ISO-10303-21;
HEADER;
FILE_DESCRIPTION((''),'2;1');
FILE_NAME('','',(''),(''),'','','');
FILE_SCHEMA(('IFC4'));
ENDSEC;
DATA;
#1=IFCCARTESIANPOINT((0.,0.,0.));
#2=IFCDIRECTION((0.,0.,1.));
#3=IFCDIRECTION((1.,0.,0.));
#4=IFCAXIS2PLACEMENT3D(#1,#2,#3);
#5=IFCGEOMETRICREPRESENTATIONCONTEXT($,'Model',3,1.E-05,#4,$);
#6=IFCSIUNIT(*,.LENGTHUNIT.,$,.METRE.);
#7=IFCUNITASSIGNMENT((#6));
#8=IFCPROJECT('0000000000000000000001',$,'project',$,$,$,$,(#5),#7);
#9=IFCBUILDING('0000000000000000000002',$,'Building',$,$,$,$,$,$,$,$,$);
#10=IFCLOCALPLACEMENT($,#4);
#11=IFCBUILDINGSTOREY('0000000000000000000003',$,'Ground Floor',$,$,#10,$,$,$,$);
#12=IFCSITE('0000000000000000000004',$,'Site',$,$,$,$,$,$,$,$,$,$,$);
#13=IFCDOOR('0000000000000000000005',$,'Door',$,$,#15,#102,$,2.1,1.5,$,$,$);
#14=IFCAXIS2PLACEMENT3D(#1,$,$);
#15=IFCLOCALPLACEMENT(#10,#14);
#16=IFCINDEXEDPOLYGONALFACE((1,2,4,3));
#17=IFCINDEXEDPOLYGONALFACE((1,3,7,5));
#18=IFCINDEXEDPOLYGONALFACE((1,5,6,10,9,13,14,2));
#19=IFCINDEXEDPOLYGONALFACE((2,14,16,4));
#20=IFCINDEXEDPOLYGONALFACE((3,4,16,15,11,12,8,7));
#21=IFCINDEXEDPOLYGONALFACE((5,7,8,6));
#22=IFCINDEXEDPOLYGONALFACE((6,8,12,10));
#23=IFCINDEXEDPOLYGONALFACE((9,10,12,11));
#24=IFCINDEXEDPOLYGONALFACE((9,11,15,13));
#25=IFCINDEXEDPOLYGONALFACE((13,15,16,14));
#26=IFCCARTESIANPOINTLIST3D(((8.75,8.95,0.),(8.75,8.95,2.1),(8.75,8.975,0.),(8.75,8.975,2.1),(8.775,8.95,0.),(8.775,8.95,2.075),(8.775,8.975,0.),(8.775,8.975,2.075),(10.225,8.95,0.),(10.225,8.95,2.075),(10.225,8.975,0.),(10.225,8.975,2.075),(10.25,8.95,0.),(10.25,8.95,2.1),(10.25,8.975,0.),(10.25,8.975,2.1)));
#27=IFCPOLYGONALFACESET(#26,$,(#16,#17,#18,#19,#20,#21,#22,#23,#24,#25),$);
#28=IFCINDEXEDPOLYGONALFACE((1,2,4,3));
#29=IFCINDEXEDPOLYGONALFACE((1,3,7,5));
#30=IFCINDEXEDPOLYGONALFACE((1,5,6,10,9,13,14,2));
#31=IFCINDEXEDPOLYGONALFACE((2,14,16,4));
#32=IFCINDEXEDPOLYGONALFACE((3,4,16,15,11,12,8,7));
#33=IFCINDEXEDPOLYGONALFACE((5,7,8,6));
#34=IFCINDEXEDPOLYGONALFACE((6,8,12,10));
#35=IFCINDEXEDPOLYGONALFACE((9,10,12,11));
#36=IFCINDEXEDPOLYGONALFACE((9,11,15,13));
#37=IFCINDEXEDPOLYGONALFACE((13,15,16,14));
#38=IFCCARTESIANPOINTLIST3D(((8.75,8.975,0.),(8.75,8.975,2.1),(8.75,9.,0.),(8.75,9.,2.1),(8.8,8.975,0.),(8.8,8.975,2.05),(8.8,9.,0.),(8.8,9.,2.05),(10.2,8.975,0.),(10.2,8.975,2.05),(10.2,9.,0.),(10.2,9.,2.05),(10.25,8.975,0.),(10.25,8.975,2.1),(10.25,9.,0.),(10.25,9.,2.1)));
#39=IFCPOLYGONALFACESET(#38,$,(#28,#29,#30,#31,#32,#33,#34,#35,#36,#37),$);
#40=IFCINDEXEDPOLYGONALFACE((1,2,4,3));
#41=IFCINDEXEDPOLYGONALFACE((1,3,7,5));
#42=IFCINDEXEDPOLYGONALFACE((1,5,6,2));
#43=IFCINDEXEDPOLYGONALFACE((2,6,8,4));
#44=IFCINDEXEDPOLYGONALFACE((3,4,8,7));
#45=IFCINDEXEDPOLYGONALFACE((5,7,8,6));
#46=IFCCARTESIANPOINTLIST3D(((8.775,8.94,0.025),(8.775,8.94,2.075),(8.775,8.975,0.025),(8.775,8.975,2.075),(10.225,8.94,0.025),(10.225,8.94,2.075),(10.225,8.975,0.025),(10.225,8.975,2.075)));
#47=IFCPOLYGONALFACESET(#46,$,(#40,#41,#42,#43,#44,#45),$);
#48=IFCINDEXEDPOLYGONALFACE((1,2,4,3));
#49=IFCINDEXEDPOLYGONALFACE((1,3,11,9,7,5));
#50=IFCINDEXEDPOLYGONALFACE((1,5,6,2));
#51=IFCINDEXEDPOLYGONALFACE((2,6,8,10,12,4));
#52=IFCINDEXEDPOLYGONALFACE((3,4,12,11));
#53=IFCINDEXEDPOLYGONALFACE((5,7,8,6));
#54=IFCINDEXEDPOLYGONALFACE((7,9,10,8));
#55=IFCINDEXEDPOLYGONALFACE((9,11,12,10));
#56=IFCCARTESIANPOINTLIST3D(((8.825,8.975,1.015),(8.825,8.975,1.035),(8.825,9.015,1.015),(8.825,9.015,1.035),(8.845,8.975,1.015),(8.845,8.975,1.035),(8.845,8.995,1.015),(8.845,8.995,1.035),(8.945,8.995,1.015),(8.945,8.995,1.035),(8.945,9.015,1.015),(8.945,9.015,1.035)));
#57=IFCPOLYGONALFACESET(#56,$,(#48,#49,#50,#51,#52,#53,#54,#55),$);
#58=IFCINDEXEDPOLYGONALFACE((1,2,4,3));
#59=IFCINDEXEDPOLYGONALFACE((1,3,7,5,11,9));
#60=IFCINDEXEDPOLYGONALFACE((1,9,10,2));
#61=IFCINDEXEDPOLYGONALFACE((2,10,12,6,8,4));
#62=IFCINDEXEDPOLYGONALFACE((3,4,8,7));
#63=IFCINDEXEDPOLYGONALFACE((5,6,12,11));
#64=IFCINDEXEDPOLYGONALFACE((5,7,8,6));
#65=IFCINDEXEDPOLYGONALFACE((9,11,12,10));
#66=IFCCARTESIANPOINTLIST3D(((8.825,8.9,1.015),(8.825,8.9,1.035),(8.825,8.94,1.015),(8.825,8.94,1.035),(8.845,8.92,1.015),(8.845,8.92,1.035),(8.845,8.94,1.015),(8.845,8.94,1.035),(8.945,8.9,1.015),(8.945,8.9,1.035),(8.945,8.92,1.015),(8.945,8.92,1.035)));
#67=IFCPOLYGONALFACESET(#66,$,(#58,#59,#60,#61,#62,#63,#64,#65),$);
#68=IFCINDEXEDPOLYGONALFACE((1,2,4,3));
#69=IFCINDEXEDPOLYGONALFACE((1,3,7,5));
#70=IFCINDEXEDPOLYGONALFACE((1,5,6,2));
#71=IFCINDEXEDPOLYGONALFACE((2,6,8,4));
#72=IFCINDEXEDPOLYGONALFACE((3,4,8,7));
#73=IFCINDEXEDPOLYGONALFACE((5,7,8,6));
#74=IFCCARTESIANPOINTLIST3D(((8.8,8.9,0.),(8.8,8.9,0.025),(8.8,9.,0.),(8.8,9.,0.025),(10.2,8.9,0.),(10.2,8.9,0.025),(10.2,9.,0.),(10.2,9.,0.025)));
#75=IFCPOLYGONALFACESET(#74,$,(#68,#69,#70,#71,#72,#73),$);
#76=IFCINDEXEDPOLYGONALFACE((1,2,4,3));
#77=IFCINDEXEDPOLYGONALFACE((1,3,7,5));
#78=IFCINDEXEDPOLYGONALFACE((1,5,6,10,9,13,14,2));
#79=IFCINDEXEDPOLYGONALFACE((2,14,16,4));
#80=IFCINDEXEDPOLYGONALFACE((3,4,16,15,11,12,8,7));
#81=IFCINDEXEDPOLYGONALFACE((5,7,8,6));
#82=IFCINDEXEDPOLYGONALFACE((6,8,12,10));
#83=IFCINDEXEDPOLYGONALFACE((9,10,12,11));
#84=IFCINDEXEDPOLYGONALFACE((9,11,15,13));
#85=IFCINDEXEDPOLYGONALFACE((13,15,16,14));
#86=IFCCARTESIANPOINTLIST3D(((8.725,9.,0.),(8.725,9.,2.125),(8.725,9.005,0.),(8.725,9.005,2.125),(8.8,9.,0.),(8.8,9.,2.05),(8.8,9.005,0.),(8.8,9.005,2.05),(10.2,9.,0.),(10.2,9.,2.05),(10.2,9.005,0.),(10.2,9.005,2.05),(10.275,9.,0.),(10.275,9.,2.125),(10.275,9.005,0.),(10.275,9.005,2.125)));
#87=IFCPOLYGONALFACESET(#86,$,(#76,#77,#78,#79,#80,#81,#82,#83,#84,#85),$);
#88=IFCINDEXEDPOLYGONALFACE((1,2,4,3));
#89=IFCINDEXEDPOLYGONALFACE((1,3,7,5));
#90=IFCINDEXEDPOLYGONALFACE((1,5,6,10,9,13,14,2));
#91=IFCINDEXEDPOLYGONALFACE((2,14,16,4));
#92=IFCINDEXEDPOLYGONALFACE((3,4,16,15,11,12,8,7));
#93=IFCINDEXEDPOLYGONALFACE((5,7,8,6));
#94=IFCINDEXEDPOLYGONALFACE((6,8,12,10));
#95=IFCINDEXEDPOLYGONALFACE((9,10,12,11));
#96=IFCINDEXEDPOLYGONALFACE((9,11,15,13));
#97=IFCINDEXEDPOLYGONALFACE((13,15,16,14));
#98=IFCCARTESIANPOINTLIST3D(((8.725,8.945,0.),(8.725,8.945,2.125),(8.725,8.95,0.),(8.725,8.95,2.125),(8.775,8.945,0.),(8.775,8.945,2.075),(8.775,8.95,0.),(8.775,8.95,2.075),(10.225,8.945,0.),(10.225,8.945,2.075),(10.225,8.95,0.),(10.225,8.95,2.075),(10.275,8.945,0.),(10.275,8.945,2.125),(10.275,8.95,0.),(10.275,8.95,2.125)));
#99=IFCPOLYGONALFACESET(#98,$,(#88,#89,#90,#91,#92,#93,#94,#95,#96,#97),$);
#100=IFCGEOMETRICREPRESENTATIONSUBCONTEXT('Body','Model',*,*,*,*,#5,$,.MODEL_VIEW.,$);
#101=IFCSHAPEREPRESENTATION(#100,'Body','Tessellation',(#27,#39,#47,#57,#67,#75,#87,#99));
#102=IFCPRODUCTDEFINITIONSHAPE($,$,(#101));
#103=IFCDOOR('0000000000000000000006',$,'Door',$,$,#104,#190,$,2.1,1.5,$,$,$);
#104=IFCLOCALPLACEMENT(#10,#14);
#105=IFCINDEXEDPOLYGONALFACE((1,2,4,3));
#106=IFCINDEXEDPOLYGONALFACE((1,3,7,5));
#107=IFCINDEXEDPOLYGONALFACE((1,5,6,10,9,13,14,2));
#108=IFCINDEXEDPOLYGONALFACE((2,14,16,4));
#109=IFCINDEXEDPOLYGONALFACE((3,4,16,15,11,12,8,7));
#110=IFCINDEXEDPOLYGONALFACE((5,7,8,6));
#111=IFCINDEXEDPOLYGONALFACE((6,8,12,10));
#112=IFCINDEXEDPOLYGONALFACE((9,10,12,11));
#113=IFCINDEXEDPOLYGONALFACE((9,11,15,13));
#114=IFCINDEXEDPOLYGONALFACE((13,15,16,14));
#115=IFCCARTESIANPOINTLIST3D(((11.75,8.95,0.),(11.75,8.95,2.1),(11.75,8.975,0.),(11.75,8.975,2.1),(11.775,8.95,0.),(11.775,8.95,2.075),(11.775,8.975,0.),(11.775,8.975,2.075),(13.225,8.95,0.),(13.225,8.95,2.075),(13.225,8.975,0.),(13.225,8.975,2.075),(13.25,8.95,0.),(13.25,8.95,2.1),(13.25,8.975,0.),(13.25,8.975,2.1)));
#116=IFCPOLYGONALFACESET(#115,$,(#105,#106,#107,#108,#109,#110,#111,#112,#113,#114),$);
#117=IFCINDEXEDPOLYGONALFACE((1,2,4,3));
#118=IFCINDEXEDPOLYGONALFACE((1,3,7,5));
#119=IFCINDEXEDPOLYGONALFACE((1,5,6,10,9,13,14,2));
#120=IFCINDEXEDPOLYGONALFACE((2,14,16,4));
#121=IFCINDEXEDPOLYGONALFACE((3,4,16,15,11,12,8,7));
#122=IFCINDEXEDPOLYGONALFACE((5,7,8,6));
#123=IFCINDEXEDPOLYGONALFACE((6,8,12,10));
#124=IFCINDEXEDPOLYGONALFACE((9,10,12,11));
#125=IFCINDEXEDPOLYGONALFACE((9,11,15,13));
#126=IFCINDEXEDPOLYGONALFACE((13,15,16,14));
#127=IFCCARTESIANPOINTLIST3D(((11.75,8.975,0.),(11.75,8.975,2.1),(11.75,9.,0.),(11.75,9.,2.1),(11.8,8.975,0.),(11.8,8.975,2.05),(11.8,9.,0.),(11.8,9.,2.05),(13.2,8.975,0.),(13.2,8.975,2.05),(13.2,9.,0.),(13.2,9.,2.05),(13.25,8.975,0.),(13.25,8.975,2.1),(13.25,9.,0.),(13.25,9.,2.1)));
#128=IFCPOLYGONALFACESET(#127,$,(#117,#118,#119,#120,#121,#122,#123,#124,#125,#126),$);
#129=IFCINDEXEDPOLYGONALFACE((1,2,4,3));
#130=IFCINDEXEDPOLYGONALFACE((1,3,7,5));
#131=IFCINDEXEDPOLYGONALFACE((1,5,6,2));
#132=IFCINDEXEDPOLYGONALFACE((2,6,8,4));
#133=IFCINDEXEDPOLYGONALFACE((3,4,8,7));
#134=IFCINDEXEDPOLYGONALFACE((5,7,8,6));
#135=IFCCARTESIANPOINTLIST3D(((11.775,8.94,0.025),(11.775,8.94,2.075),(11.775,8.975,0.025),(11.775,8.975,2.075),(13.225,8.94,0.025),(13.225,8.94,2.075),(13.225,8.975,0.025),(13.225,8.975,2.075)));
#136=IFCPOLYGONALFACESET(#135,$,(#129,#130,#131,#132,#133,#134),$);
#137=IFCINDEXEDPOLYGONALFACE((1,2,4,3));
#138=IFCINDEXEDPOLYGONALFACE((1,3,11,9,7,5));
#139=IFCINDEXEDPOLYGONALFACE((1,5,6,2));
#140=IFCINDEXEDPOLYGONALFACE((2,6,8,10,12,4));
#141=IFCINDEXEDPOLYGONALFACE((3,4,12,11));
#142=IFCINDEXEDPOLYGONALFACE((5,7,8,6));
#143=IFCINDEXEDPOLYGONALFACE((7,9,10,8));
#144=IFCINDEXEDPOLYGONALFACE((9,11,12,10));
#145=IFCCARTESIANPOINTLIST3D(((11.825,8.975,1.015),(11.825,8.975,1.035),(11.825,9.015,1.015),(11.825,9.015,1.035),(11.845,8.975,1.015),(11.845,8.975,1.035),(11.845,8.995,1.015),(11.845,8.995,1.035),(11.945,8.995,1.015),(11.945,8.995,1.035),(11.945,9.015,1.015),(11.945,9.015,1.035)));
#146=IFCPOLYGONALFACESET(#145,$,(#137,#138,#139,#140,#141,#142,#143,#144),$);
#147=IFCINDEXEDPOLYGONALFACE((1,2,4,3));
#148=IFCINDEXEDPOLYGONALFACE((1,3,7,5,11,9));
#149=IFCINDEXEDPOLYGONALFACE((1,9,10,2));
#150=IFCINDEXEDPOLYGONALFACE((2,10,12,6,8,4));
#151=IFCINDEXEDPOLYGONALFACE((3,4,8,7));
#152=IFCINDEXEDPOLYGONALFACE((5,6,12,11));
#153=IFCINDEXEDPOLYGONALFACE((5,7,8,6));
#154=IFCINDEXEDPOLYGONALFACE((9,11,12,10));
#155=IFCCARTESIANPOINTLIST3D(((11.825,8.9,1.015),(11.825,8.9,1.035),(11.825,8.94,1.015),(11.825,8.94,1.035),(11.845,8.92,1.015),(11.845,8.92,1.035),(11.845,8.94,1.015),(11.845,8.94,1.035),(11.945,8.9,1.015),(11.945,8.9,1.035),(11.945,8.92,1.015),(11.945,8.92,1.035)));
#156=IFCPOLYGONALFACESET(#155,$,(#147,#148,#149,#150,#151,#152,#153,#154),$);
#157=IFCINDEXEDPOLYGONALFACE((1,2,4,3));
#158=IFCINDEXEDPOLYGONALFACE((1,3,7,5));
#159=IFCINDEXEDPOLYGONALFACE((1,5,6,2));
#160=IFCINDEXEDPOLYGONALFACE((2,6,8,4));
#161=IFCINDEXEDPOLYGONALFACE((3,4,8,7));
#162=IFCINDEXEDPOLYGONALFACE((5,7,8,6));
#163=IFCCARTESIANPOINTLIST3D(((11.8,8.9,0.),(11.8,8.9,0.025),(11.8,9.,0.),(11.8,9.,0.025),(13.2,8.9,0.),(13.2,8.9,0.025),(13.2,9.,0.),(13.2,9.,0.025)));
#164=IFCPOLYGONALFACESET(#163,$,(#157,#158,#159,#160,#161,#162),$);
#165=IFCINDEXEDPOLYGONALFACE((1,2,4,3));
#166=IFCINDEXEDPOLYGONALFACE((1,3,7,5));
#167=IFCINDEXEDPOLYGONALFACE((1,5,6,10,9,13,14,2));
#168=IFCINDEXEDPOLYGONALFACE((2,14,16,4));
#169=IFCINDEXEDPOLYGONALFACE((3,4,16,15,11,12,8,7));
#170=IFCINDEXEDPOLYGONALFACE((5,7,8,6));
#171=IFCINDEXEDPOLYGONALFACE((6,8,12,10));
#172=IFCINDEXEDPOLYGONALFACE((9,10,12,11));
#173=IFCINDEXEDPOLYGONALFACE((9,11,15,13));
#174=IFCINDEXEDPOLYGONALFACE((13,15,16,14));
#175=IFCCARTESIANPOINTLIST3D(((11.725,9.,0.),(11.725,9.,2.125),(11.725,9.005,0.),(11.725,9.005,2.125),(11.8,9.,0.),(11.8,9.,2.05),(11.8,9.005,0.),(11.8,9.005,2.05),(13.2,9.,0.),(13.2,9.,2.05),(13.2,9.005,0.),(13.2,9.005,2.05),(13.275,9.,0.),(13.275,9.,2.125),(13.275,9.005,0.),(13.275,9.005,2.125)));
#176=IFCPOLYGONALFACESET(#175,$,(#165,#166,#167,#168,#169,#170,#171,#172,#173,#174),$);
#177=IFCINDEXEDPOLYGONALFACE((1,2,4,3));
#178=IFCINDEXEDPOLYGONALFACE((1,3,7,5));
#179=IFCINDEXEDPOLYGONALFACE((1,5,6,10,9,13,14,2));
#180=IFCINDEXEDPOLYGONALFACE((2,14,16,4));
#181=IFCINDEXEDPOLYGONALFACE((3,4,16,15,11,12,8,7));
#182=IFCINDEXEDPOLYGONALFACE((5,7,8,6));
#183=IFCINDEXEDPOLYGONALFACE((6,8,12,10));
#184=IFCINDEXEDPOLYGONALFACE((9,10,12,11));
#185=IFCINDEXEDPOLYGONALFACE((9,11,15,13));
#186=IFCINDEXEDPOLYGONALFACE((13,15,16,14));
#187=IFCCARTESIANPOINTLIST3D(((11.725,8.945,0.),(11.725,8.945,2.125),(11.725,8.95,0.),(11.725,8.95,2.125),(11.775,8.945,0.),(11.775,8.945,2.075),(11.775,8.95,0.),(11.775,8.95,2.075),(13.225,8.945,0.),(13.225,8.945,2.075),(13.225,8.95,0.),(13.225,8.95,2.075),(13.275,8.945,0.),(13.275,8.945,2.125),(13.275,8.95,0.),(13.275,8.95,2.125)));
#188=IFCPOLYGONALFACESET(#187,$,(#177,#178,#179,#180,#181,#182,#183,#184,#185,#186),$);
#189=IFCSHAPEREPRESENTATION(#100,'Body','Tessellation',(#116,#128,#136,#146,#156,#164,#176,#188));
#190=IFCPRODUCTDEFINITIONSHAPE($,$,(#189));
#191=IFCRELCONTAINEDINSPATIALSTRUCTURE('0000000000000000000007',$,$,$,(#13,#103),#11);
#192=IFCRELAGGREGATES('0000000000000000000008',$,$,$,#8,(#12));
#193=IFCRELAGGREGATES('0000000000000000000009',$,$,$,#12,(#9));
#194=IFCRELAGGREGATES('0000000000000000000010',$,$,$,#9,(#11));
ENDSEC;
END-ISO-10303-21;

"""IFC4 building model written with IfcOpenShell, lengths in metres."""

from ifc_helpers import new_model, si_unit, frame, origin_with_axes, place, context, subcontext, project, spatial, line, indexed_curve, outline, extrude, element, save


model = new_model("IFC4")

# Units and contexts
model_context = context("Model", 3, precision=1e-05, world=origin_with_axes())
body_context = subcontext(model_context, "Body", "Model", "MODEL_VIEW")
ifc_project = project(units=[si_unit("LENGTHUNIT", "METRE")], contexts=[model_context])

# Site, building, storey
site = spatial("IfcSite", under=ifc_project, Name="Site")
building = spatial("IfcBuilding", under=site, Name="Building")
storey_placement = place(None, origin_with_axes())
storey = spatial("IfcBuildingStorey", under=building, at=storey_placement, Name="Ground Floor")

# Doors
door_1_placement = place(storey_placement, frame((10.25, 9.0, 0.0), z_axis=(0.0, 0.0, 1.0), x_axis=(-1.0, 0.0, 0.0)))
element("IfcDoor", 1, at=door_1_placement, inside=storey, Name="Door", OverallHeight=2.1, OverallWidth=1.5, context=body_context, shape_type="SweptSolid", body=[
    extrude(outline(indexed_curve([(0.0, 0.0), (0.0, 2.1), (1.5, 2.1), (1.5, 0.0), (1.475, 0.0), (1.475, 2.075), (0.025, 2.075), (0.025, 0.0)], segments=[line(1, 2, 3, 4, 5, 6, 7, 8, 1)])), frame((0.0, 0.025, 0.0), z_axis=(0.0, -1.0, 0.0), x_axis=(1.0, 0.0, 0.0)), (0.0, 0.0, -1.0), 0.025),
    extrude(outline(indexed_curve([(0.0, 0.0), (0.0, 2.1), (1.5, 2.1), (1.5, 0.0), (1.45, 0.0), (1.45, 2.05), (0.05, 2.05), (0.05, 0.0)], segments=[line(1, 2, 3, 4, 5, 6, 7, 8, 1)])), frame((0.0, 0.0, 0.0), z_axis=(0.0, -1.0, 0.0), x_axis=(1.0, 0.0, 0.0)), (0.0, 0.0, -1.0), 0.025),
    extrude(outline(indexed_curve([(0.0, 0.0), (1.45, 0.0), (1.45, 0.035), (0.0, 0.035)], segments=[line(1, 2, 3, 4, 1)])), frame((0.025, 0.025, 0.025), z_axis=(0.0, 0.0, 1.0), x_axis=(1.0, 0.0, 0.0)), (0.0, 0.0, 1.0), 2.05),
    extrude(outline(indexed_curve([(0.0, 0.0), (0.0, -0.04), (-0.12, -0.04), (-0.12, -0.02), (-0.02, -0.02), (-0.02, 0.0)], segments=[line(1, 2, 3, 4, 5, 6, 1)])), frame((1.425, 0.025, 1.015), z_axis=(0.0, 0.0, 1.0), x_axis=(1.0, 0.0, 0.0)), (0.0, 0.0, 1.0), 0.02),
    extrude(outline(indexed_curve([(0.0, 0.0), (0.0, 0.04), (-0.12, 0.04), (-0.12, 0.02), (-0.02, 0.02), (-0.02, 0.0)], segments=[line(1, 2, 3, 4, 5, 6, 1)])), frame((1.425, 0.06, 1.015), z_axis=(0.0, 0.0, 1.0), x_axis=(1.0, 0.0, 0.0)), (0.0, 0.0, 1.0), 0.02),
    extrude(outline(indexed_curve([(0.0, 0.0), (1.4, 0.0), (1.4, 0.1), (0.0, 0.1)], segments=[line(1, 2, 3, 4, 1)])), frame((0.05, 0.0, 0.0), z_axis=(0.0, 0.0, 1.0), x_axis=(1.0, 0.0, 0.0)), (0.0, 0.0, 1.0), 0.025),
    extrude(outline(indexed_curve([(0.0, 0.0), (0.0, 2.125), (1.55, 2.125), (1.55, 0.0), (1.475, 0.0), (1.475, 2.05), (0.075, 2.05), (0.075, 0.0)], segments=[line(1, 2, 3, 4, 5, 6, 7, 8, 1)])), frame((-0.025, -0.005, 0.0), z_axis=(0.0, -1.0, 0.0), x_axis=(1.0, 0.0, 0.0)), (0.0, 0.0, -1.0), 0.005),
    extrude(outline(indexed_curve([(0.0, 0.0), (0.0, 2.125), (1.55, 2.125), (1.55, 0.0), (1.5, 0.0), (1.5, 2.075), (0.05, 2.075), (0.05, 0.0)], segments=[line(1, 2, 3, 4, 5, 6, 7, 8, 1)])), frame((-0.025, 0.05, 0.0), z_axis=(0.0, -1.0, 0.0), x_axis=(1.0, 0.0, 0.0)), (0.0, 0.0, -1.0), 0.005),
])
door_2_placement = place(storey_placement, frame((13.25, 9.0, 0.0), z_axis=(0.0, 0.0, 1.0), x_axis=(-1.0, 0.0, 0.0)))
element("IfcDoor", 2, at=door_2_placement, inside=storey, Name="Door", OverallHeight=2.1, OverallWidth=1.5, context=body_context, shape_type="SweptSolid", body=[
    extrude(outline(indexed_curve([(0.0, 0.0), (0.0, 2.1), (1.5, 2.1), (1.5, 0.0), (1.475, 0.0), (1.475, 2.075), (0.025, 2.075), (0.025, 0.0)], segments=[line(1, 2, 3, 4, 5, 6, 7, 8, 1)])), frame((0.0, 0.025, 0.0), z_axis=(0.0, -1.0, 0.0), x_axis=(1.0, 0.0, 0.0)), (0.0, 0.0, -1.0), 0.025),
    extrude(outline(indexed_curve([(0.0, 0.0), (0.0, 2.1), (1.5, 2.1), (1.5, 0.0), (1.45, 0.0), (1.45, 2.05), (0.05, 2.05), (0.05, 0.0)], segments=[line(1, 2, 3, 4, 5, 6, 7, 8, 1)])), frame((0.0, 0.0, 0.0), z_axis=(0.0, -1.0, 0.0), x_axis=(1.0, 0.0, 0.0)), (0.0, 0.0, -1.0), 0.025),
    extrude(outline(indexed_curve([(0.0, 0.0), (1.45, 0.0), (1.45, 0.035), (0.0, 0.035)], segments=[line(1, 2, 3, 4, 1)])), frame((0.025, 0.025, 0.025), z_axis=(0.0, 0.0, 1.0), x_axis=(1.0, 0.0, 0.0)), (0.0, 0.0, 1.0), 2.05),
    extrude(outline(indexed_curve([(0.0, 0.0), (0.0, -0.04), (-0.12, -0.04), (-0.12, -0.02), (-0.02, -0.02), (-0.02, 0.0)], segments=[line(1, 2, 3, 4, 5, 6, 1)])), frame((1.425, 0.025, 1.015), z_axis=(0.0, 0.0, 1.0), x_axis=(1.0, 0.0, 0.0)), (0.0, 0.0, 1.0), 0.02),
    extrude(outline(indexed_curve([(0.0, 0.0), (0.0, 0.04), (-0.12, 0.04), (-0.12, 0.02), (-0.02, 0.02), (-0.02, 0.0)], segments=[line(1, 2, 3, 4, 5, 6, 1)])), frame((1.425, 0.06, 1.015), z_axis=(0.0, 0.0, 1.0), x_axis=(1.0, 0.0, 0.0)), (0.0, 0.0, 1.0), 0.02),
    extrude(outline(indexed_curve([(0.0, 0.0), (1.4, 0.0), (1.4, 0.1), (0.0, 0.1)], segments=[line(1, 2, 3, 4, 1)])), frame((0.05, 0.0, 0.0), z_axis=(0.0, 0.0, 1.0), x_axis=(1.0, 0.0, 0.0)), (0.0, 0.0, 1.0), 0.025),
    extrude(outline(indexed_curve([(0.0, 0.0), (0.0, 2.125), (1.55, 2.125), (1.55, 0.0), (1.475, 0.0), (1.475, 2.05), (0.075, 2.05), (0.075, 0.0)], segments=[line(1, 2, 3, 4, 5, 6, 7, 8, 1)])), frame((-0.025, -0.005, 0.0), z_axis=(0.0, -1.0, 0.0), x_axis=(1.0, 0.0, 0.0)), (0.0, 0.0, -1.0), 0.005),
    extrude(outline(indexed_curve([(0.0, 0.0), (0.0, 2.125), (1.55, 2.125), (1.55, 0.0), (1.5, 0.0), (1.5, 2.075), (0.05, 2.075), (0.05, 0.0)], segments=[line(1, 2, 3, 4, 5, 6, 7, 8, 1)])), frame((-0.025, 0.05, 0.0), z_axis=(0.0, -1.0, 0.0), x_axis=(1.0, 0.0, 0.0)), (0.0, 0.0, -1.0), 0.005),
])

save(model, "model.ifc")
